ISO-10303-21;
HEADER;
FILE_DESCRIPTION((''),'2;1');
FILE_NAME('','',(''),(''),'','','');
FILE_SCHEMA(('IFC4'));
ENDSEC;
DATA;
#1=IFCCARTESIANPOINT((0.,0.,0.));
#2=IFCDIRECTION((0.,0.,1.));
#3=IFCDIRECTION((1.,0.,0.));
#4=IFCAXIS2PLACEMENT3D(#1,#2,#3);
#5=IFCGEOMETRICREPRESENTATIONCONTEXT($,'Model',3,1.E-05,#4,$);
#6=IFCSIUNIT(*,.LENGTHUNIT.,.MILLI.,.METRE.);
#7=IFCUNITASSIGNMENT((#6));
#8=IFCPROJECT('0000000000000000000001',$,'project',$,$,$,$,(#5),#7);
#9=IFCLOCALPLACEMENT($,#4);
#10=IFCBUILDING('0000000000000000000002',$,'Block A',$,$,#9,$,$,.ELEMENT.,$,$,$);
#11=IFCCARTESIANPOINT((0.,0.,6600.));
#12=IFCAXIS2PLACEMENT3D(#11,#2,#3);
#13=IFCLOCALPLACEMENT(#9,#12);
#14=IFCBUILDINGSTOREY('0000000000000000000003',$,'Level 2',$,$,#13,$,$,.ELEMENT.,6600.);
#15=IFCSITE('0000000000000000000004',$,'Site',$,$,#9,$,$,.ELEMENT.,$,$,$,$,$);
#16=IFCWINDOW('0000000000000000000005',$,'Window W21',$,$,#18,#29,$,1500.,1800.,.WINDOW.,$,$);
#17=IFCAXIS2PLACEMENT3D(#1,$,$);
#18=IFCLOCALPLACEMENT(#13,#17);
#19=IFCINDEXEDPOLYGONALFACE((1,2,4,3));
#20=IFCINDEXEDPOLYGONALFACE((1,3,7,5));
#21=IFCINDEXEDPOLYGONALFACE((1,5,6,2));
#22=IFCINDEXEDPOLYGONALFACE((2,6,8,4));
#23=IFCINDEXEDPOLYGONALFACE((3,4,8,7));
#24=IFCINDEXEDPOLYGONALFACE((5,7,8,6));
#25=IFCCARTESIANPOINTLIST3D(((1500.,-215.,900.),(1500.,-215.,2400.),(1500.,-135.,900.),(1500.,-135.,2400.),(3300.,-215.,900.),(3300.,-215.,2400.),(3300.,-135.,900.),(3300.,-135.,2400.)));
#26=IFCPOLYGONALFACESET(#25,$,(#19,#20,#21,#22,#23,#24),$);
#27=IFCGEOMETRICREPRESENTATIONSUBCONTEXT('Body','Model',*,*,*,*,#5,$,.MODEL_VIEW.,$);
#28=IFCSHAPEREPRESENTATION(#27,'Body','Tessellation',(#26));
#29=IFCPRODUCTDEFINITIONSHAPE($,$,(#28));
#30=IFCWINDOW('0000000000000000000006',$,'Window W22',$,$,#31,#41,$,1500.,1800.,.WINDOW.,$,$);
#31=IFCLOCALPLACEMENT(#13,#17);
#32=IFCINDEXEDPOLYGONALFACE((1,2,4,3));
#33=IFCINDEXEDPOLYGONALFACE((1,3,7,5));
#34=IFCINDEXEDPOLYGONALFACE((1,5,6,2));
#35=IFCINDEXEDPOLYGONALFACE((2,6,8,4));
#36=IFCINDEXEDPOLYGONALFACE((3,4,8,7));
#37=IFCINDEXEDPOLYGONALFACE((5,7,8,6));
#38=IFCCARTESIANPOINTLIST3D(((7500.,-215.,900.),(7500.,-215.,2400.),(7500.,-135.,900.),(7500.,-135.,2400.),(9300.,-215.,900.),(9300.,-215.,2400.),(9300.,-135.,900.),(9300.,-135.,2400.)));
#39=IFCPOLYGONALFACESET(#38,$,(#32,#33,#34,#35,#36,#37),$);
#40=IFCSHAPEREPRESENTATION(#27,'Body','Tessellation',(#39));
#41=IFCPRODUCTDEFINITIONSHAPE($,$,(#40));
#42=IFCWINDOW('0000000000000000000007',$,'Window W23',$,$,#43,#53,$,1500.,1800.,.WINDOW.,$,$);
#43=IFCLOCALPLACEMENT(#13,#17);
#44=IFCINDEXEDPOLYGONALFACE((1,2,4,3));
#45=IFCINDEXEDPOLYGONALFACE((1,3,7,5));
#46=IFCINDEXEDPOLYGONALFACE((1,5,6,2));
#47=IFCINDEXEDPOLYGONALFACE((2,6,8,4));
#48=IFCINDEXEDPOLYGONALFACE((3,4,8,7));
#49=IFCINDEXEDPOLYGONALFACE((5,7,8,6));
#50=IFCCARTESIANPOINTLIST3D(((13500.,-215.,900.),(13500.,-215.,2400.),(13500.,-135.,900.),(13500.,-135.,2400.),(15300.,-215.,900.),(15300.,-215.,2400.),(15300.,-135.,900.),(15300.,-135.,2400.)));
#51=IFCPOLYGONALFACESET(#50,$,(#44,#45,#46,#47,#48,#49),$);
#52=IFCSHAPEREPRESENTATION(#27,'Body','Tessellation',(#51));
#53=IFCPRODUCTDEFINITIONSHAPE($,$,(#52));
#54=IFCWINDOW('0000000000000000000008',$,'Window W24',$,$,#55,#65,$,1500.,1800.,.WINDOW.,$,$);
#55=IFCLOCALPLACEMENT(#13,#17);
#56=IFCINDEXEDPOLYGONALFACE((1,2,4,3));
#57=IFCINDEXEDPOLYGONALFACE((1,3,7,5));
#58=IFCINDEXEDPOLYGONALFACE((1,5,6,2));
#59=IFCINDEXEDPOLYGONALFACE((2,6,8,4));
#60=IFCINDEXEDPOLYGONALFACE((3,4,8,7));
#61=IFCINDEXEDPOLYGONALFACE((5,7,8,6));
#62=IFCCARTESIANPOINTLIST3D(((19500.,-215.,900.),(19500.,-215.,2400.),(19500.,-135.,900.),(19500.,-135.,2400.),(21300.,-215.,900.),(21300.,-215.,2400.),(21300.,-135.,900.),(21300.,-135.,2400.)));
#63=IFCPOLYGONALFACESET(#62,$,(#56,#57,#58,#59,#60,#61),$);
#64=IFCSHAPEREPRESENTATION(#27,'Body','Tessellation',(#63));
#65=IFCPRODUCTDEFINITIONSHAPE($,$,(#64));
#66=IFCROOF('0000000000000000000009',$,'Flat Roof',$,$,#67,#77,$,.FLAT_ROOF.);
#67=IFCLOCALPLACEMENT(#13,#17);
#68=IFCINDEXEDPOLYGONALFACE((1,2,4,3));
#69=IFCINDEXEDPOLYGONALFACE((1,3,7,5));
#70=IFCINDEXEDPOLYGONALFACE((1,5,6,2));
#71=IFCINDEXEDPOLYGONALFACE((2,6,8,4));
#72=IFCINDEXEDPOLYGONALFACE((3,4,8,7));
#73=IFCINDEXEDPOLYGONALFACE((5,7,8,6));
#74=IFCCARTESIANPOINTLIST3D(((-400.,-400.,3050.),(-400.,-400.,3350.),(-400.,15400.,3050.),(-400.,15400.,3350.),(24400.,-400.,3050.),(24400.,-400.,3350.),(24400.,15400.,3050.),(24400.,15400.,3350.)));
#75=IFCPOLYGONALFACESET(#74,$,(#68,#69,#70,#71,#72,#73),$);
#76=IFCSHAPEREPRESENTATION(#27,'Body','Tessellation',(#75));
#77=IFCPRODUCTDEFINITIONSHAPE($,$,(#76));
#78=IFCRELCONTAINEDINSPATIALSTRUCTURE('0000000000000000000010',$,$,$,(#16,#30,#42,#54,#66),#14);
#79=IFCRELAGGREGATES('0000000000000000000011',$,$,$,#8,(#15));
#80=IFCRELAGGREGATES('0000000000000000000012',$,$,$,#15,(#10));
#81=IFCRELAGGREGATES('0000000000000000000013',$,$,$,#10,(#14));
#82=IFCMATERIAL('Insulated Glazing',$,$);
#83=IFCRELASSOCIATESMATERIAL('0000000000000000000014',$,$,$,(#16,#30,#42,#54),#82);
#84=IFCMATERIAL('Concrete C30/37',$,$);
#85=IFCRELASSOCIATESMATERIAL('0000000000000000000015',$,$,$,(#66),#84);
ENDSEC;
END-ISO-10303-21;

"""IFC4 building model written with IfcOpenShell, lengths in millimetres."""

from ifc_helpers import new_model, si_unit, frame, frame_2d, origin_with_axes, place, context, subcontext, project, spatial, rectangle, extrude, material, element, save


model = new_model("IFC4")

# Units and contexts
model_context = context("Model", 3, precision=1e-05, world=origin_with_axes())
body_context = subcontext(model_context, "Body", "Model", "MODEL_VIEW")
ifc_project = project(units=[si_unit("LENGTHUNIT", "METRE", prefix="MILLI")], contexts=[model_context])

# Site, building, storey
placement = place(None, origin_with_axes())
site = spatial("IfcSite", under=ifc_project, at=placement, Name="Site", CompositionType="ELEMENT")
building = spatial("IfcBuilding", under=site, at=placement, Name="Block A", CompositionType="ELEMENT")
storey_placement = place(placement, frame((0.0, 0.0, 6600.0), z_axis=(0.0, 0.0, 1.0), x_axis=(1.0, 0.0, 0.0)))
storey = spatial("IfcBuildingStorey", under=building, at=storey_placement, Name="Level 2", CompositionType="ELEMENT", Elevation=6600.0)

# Shared definitions
ifc_material_1 = material(Name="Concrete C30/37")

# Windows
ifc_material_2 = material(Name="Insulated Glazing")
for number, where, z_axis, x_axis, name in (
    (1, (1500.0, -215.0, 7500.0), (0.0, 0.0, 1.0), (1.0, 0.0, 0.0), "Window W21"),
    (2, (7500.0, -215.0, 7500.0), (0.0, 0.0, 1.0), (1.0, 0.0, 0.0), "Window W22"),
    (3, (13500.0, -215.0, 7500.0), (0.0, 0.0, 1.0), (1.0, 0.0, 0.0), "Window W23"),
    (4, (19500.0, -215.0, 7500.0), (0.0, 0.0, 1.0), (1.0, 0.0, 0.0), "Window W24"),
):
    element("IfcWindow", number, at=place(placement, frame(where, z_axis=z_axis, x_axis=x_axis)), inside=storey, material=ifc_material_2, Name=name, OverallHeight=1500.0, OverallWidth=1800.0, PredefinedType="WINDOW", context=body_context, shape_type="SweptSolid", body=[
        extrude(rectangle(XDim=1800.0, YDim=80.0, at=frame_2d((900.0, 40.0))), origin_with_axes(), (0.0, 0.0, 1.0), 1500.0),
    ])

# Roof
roof_placement = place(placement, frame((-400.0, -400.0, 9650.0), z_axis=(0.0, 0.0, 1.0), x_axis=(1.0, 0.0, 0.0)))
element("IfcRoof", 5, at=roof_placement, inside=storey, material=ifc_material_1, Name="Flat Roof", PredefinedType="FLAT_ROOF", context=body_context, shape_type="SweptSolid", body=[
    extrude(rectangle(XDim=24800.0, YDim=15800.0, at=frame_2d((12400.0, 7900.0))), origin_with_axes(), (0.0, 0.0, 1.0), 300.0),
])

save(model, "model.ifc")
